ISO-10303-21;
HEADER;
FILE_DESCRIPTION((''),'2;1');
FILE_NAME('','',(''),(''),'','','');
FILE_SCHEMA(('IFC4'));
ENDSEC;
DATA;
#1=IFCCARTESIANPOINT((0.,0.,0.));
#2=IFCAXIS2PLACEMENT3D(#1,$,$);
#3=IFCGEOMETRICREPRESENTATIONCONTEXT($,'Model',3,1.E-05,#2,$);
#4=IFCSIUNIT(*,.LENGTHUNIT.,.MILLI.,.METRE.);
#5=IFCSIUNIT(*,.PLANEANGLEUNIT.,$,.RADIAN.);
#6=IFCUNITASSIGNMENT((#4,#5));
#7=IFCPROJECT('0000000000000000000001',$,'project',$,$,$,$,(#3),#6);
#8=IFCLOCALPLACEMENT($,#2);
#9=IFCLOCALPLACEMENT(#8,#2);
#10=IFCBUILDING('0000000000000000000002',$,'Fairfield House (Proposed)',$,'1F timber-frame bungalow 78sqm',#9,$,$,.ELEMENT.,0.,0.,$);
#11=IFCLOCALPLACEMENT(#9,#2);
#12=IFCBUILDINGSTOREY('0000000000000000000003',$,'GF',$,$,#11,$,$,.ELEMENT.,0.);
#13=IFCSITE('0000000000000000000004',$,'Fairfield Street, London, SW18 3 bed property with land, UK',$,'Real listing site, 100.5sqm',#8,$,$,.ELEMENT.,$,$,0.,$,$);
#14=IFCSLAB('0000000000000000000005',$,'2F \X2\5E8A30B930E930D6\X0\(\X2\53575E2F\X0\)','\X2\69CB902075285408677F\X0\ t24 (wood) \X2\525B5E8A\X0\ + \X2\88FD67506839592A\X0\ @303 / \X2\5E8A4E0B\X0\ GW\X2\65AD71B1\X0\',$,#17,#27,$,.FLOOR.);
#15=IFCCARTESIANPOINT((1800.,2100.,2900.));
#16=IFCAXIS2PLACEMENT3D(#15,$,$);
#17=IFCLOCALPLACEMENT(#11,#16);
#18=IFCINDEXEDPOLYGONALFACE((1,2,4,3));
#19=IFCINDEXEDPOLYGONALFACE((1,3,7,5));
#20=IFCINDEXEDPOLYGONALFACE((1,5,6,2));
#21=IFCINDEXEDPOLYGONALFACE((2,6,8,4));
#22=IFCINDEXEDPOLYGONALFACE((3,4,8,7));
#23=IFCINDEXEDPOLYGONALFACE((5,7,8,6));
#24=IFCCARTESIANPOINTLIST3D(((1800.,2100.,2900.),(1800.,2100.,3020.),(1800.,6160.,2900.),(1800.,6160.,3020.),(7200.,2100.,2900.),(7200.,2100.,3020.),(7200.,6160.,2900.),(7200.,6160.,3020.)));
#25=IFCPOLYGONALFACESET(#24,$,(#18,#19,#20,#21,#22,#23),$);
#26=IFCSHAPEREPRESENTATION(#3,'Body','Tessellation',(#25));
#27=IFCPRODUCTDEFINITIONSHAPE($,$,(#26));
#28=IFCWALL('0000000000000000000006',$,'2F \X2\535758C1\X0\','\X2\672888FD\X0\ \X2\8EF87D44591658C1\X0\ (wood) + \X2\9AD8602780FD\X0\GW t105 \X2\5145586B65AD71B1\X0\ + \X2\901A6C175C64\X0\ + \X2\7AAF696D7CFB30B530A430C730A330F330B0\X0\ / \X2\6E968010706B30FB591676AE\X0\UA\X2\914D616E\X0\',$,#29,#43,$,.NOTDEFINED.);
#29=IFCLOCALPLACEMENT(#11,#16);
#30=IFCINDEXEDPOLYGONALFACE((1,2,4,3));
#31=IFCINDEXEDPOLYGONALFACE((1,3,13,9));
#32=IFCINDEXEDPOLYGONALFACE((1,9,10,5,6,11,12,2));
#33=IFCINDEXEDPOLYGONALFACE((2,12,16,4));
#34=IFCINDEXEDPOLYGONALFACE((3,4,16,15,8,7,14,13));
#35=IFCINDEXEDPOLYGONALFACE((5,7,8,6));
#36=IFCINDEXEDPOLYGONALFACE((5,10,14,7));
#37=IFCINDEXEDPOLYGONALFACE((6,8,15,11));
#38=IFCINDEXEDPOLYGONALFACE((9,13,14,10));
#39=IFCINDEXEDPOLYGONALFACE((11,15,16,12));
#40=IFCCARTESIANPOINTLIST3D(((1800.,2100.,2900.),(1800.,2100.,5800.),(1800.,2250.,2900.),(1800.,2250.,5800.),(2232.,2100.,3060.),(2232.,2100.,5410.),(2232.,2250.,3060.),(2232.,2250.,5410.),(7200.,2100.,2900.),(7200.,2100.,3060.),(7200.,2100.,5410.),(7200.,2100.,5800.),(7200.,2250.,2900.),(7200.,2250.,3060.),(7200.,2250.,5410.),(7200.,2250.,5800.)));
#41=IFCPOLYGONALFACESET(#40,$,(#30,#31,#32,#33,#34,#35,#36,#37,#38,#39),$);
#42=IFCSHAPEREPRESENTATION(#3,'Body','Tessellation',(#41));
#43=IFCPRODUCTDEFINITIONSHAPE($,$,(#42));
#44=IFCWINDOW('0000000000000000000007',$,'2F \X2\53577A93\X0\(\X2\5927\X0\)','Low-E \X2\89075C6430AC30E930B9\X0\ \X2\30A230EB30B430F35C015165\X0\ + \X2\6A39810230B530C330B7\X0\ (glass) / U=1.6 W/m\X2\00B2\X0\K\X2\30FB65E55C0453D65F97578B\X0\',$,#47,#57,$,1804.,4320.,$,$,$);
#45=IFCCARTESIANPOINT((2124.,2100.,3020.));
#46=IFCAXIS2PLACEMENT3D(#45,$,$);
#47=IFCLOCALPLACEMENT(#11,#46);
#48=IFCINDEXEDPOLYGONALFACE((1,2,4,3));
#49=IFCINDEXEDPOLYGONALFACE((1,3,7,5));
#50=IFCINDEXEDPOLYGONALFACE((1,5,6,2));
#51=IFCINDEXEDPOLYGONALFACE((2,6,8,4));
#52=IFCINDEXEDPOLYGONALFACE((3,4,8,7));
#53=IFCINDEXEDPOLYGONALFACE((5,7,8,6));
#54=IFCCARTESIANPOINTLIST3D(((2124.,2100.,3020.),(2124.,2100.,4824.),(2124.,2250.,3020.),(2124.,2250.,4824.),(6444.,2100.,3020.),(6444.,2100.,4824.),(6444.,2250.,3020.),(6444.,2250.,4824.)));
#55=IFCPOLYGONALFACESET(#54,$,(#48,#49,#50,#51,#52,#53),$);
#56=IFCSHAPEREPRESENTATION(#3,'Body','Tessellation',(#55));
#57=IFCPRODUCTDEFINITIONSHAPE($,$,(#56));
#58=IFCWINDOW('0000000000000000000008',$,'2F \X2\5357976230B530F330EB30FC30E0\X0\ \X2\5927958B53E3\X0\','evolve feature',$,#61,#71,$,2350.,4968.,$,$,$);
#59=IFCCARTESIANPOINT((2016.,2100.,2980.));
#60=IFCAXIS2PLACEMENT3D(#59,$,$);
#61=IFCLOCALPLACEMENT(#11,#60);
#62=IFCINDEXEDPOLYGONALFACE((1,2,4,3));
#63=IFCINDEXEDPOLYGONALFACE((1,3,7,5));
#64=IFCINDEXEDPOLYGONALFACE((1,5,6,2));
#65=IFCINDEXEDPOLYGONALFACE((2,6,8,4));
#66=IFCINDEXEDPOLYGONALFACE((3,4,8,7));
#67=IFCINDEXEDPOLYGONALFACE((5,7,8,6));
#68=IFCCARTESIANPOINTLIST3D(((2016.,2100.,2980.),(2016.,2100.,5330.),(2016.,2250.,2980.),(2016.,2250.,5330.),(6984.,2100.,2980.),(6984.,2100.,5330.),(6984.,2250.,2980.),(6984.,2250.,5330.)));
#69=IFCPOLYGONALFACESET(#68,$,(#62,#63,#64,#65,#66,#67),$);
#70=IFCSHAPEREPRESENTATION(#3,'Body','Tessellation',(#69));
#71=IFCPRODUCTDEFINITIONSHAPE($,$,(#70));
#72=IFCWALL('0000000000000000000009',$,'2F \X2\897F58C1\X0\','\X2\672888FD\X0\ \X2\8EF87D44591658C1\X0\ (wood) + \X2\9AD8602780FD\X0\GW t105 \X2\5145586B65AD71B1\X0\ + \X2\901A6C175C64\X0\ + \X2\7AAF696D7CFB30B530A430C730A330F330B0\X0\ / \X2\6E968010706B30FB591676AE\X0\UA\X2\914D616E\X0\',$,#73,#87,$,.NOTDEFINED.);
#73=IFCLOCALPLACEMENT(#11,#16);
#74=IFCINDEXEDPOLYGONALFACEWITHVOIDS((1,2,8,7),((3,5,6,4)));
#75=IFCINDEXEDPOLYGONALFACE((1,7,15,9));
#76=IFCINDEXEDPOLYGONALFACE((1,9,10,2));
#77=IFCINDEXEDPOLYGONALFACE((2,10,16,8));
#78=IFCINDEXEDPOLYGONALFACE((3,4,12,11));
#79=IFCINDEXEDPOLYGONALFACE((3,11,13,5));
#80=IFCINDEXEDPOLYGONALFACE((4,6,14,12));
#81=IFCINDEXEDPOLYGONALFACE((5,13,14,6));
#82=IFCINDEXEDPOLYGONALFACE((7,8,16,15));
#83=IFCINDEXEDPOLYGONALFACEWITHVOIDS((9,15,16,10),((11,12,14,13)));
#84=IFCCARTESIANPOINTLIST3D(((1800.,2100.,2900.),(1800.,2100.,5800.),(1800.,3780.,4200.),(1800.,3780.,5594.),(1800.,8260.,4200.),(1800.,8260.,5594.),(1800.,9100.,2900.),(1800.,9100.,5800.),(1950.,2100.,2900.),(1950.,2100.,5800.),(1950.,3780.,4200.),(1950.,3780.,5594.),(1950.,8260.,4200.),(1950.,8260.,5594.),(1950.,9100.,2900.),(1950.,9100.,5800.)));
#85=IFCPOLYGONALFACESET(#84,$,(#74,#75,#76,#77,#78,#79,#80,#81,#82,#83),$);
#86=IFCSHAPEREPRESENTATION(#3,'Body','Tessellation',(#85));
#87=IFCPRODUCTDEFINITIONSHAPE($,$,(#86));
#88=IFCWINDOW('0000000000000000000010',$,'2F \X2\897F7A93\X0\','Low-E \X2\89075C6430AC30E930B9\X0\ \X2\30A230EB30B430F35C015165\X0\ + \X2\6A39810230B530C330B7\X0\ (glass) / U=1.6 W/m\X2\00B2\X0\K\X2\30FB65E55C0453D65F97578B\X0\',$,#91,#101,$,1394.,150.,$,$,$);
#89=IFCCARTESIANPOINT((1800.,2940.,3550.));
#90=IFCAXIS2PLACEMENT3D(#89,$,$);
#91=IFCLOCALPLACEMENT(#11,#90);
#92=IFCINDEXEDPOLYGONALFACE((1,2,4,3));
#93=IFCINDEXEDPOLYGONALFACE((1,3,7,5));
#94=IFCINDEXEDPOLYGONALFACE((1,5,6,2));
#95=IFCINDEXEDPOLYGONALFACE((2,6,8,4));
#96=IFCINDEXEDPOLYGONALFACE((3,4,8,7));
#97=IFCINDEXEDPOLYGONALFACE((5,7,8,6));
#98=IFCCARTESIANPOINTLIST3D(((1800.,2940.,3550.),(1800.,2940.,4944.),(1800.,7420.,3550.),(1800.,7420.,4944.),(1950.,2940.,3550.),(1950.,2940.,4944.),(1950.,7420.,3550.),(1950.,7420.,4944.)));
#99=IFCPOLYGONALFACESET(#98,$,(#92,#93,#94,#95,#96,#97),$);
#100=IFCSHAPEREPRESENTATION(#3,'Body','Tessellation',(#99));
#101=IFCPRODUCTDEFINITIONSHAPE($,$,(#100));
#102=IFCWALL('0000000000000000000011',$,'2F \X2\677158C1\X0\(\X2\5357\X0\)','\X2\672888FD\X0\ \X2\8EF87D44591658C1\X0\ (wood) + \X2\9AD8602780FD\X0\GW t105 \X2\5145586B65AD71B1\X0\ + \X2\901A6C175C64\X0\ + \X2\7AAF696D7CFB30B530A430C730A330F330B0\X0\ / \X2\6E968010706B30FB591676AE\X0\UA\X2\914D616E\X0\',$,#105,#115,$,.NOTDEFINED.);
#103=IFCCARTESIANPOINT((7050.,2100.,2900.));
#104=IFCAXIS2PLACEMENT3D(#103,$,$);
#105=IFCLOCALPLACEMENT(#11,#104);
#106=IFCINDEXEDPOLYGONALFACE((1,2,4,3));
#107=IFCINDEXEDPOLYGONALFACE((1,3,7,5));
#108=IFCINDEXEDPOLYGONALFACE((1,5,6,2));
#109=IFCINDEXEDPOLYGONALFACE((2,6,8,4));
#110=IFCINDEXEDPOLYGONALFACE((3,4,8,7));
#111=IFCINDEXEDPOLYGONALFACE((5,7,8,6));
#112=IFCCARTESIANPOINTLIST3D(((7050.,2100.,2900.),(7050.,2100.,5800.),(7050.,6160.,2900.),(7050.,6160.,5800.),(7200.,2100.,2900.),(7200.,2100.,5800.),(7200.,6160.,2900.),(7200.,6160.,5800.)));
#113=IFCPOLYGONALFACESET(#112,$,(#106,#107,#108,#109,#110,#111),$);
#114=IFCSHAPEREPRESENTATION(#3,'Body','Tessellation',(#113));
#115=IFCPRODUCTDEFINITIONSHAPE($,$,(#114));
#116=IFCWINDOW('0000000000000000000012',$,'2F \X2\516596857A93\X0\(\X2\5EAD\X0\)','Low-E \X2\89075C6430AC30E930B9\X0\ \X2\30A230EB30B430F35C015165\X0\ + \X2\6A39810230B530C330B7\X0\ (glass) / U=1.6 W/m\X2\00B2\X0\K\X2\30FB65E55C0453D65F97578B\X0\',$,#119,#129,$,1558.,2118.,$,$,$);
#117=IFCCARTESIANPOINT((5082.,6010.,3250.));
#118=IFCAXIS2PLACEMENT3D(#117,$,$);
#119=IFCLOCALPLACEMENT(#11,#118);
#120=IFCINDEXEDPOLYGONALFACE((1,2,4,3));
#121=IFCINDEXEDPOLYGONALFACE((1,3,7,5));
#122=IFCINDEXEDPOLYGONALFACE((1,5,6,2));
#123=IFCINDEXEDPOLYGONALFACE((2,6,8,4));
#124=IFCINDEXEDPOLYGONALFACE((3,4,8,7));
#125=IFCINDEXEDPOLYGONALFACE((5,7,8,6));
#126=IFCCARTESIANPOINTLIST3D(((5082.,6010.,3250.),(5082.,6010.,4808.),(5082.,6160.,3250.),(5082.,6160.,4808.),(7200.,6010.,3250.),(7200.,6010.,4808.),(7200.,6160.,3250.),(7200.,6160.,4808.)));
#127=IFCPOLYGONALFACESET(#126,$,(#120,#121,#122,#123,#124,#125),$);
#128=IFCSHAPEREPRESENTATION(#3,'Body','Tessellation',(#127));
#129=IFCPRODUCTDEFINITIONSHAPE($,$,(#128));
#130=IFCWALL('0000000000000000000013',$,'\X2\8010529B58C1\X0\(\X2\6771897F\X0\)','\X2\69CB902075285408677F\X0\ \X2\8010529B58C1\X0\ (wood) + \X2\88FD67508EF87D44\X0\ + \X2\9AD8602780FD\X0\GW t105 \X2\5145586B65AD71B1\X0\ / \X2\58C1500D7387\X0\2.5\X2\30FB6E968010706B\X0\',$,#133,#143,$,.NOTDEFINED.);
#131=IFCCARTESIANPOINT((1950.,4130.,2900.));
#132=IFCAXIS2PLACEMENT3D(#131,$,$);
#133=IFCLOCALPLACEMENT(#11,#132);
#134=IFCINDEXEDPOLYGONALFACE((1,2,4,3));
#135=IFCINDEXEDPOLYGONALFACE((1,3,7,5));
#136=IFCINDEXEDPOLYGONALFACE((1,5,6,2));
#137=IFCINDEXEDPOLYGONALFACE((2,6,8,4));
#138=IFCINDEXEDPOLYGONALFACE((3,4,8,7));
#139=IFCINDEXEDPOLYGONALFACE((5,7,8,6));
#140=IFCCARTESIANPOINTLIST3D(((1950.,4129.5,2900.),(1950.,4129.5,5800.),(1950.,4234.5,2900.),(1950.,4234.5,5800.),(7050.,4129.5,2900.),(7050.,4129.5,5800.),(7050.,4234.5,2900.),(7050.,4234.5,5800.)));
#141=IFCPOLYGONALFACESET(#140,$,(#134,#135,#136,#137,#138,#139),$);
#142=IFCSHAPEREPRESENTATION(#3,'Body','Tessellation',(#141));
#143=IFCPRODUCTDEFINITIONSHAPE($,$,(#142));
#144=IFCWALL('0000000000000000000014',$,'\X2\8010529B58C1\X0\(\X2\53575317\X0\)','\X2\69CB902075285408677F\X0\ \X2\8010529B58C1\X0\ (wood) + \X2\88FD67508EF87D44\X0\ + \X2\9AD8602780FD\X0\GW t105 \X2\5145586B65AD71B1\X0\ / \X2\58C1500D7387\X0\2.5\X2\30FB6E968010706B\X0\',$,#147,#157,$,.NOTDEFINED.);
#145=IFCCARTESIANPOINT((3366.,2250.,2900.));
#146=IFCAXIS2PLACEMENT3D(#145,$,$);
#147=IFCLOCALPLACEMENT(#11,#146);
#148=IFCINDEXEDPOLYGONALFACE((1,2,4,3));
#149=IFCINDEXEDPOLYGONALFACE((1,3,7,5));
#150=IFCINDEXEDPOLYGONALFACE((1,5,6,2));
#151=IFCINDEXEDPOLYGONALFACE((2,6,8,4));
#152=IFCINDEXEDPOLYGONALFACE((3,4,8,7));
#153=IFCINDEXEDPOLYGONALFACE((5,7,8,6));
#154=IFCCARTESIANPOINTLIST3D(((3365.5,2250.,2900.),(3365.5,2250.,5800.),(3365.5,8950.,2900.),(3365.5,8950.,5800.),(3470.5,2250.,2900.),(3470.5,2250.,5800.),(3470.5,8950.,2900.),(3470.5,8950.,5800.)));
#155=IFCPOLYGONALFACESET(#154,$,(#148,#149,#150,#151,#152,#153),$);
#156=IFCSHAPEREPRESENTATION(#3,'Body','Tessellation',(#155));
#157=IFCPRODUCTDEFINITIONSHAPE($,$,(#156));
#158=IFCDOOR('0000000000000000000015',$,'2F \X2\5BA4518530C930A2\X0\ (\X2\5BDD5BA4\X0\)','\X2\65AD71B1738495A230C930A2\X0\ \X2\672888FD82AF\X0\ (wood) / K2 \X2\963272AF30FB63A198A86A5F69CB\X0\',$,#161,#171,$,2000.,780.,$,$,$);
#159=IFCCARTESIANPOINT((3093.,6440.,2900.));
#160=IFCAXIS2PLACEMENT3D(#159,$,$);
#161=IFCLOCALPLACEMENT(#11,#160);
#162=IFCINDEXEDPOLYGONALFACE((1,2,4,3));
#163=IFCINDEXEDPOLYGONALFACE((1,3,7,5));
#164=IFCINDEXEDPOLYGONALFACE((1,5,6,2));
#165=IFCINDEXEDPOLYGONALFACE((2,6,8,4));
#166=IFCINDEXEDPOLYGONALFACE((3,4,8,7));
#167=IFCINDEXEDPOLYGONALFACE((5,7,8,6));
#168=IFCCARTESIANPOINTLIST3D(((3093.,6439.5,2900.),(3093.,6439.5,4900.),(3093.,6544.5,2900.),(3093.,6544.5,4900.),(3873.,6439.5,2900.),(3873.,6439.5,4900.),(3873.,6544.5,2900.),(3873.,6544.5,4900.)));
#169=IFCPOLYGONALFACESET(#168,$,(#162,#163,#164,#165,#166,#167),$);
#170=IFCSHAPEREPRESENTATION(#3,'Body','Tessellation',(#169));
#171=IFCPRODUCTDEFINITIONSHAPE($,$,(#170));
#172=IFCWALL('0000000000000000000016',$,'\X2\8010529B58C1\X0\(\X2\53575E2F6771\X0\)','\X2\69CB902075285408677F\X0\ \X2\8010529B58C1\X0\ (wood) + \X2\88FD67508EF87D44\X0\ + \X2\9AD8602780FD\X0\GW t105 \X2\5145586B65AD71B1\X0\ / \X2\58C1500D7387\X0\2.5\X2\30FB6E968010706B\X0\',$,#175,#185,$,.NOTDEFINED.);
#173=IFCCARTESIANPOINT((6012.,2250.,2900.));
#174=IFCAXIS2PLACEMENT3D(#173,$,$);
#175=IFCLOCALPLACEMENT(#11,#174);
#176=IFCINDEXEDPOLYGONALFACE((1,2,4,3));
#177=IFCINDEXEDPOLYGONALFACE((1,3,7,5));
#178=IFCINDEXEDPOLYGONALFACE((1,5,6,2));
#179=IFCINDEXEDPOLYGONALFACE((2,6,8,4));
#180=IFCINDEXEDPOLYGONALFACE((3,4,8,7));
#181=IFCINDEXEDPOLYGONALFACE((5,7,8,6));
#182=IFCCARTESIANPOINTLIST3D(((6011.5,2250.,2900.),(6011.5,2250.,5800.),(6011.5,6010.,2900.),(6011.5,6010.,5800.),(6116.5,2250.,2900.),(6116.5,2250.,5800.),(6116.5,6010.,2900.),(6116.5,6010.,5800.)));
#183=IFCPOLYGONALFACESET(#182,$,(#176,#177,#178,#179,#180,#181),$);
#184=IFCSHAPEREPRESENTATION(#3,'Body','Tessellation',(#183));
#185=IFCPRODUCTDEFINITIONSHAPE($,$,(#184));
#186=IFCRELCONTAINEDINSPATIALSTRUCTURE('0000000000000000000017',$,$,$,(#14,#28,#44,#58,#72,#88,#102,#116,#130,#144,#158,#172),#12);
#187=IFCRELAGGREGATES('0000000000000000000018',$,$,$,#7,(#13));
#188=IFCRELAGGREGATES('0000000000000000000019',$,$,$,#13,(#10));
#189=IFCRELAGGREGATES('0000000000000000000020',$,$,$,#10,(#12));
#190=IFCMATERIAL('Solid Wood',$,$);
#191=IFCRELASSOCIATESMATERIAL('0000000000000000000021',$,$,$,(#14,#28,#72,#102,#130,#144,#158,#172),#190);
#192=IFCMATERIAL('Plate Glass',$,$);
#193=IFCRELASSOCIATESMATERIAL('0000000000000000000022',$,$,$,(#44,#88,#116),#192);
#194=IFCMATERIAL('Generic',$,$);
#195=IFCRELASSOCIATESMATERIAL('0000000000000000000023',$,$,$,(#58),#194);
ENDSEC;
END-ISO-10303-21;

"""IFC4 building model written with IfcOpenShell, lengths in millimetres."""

from ifc_helpers import new_model, si_unit, frame, frame_2d, origin, place, context, project, spatial, rectangle, extrude, material, element, fill, save


model = new_model("IFC4")

# Units and contexts
model_context = context("Model", 3, precision=1e-05, world=origin())
ifc_project = project(units=[si_unit("LENGTHUNIT", "METRE", prefix="MILLI"), si_unit("PLANEANGLEUNIT", "RADIAN")], contexts=[model_context])

# Site, building, storey
site_placement = place(None, origin())
site = spatial("IfcSite", under=ifc_project, at=site_placement, Name="Fairfield Street, London, SW18 3 bed property with land, UK", ObjectType="Real listing site, 100.5sqm", CompositionType="ELEMENT", RefElevation=0.0)
building_placement = place(site_placement, origin())
building = spatial("IfcBuilding", under=site, at=building_placement, Name="Fairfield House (Proposed)", ObjectType="1F timber-frame bungalow 78sqm", CompositionType="ELEMENT", ElevationOfRefHeight=0.0, ElevationOfTerrain=0.0)
storey_placement = place(building_placement, origin())
storey = spatial("IfcBuildingStorey", under=building, at=storey_placement, Name="GF", CompositionType="ELEMENT", Elevation=0.0)

# Slab
ifc_material_1 = material(Name="Solid Wood")
slab_placement = place(storey_placement, frame((1800.0, 2100.0, 2900.0)))
element("IfcSlab", 1, at=slab_placement, inside=storey, material=ifc_material_1, Name="2F 床スラブ(南帯)", Description="構造用合板 t24 (wood) 剛床 + 製材根太 @303 / 床下 GW断熱", PredefinedType="FLOOR", context=model_context, shape_type="SweptSolid", body=[
    extrude(rectangle(XDim=5400.0, YDim=4060.0, at=frame_2d((2700.0, 2030.0))), frame((1800.0, 2100.0, 2900.0)), (0.0, 0.0, 1.0), 120.0),
])

# Wall, openings, windows
wall_1_placement = place(storey_placement, frame((1800.0, 2100.0, 2900.0)))
wall_1 = element("IfcWall", 2, at=wall_1_placement, inside=storey, material=ifc_material_1, Name="2F 南壁", Description="木製 軸組外壁 (wood) + 高性能GW t105 充填断熱 + 通気層 + 窯業系サイディング / 準耐火・外皮UA配慮", PredefinedType="NOTDEFINED", context=model_context, shape_type="SweptSolid", body=[
    extrude(rectangle(XDim=5400.0, YDim=150.0, at=frame_2d((2700.0, 75.0))), frame((1800.0, 2100.0, 2900.0)), (0.0, 0.0, 1.0), 2900.0),
])
opening_1_placement = place(storey_placement, frame((2124.0, 2100.0, 3020.0)))
opening_1 = element("IfcOpeningElement", 3, at=opening_1_placement, cuts=wall_1, PredefinedType="NOTDEFINED", context=model_context, shape_type="SweptSolid", body=[
    extrude(rectangle(XDim=4320.0, YDim=150.0, at=frame_2d((2160.0, 75.0))), frame((2124.0, 2100.0, 3020.0)), (0.0, 0.0, 1.0), 1804.0),
])
opening_2_placement = place(storey_placement, frame((2016.0, 2100.0, 2980.0)))
opening_2 = element("IfcOpeningElement", 4, at=opening_2_placement, cuts=wall_1, PredefinedType="NOTDEFINED", context=model_context, shape_type="SweptSolid", body=[
    extrude(rectangle(XDim=4968.0, YDim=150.0, at=frame_2d((2484.0, 75.0))), frame((2016.0, 2100.0, 2980.0)), (0.0, 0.0, 1.0), 2350.0),
])
ifc_material_2 = material(Name="Plate Glass")
window_1_placement = place(storey_placement, frame((2124.0, 2100.0, 3020.0)))
window_1 = element("IfcWindow", 5, at=window_1_placement, inside=storey, material=ifc_material_2, Name="2F 南窓(大)", Description="Low-E 複層ガラス アルゴン封入 + 樹脂サッシ (glass) / U=1.6 W/m²K・日射取得型", OverallHeight=1804.0, OverallWidth=4320.0, context=model_context, shape_type="SweptSolid", body=[
    extrude(rectangle(XDim=4320.0, YDim=150.0, at=frame_2d((2160.0, 75.0))), frame((2124.0, 2100.0, 3020.0)), (0.0, 0.0, 1.0), 1804.0),
])
fill(opening_1, window_1)
ifc_material_3 = material(Name="Generic")
window_2_placement = place(storey_placement, frame((2016.0, 2100.0, 2980.0)))
window_2 = element("IfcWindow", 6, at=window_2_placement, inside=storey, material=ifc_material_3, Name="2F 南面サンルーム 大開口", Description="evolve feature", OverallHeight=2350.0, OverallWidth=4968.0, context=model_context, shape_type="SweptSolid", body=[
    extrude(rectangle(XDim=4968.0, YDim=150.0, at=frame_2d((2484.0, 75.0))), frame((2016.0, 2100.0, 2980.0)), (0.0, 0.0, 1.0), 2350.0),
])
fill(opening_2, window_2)

# Walls, openings, windows
wall_2_placement = place(storey_placement, frame((1800.0, 2100.0, 2900.0)))
wall_2 = element("IfcWall", 7, at=wall_2_placement, inside=storey, material=ifc_material_1, Name="2F 西壁", Description="木製 軸組外壁 (wood) + 高性能GW t105 充填断熱 + 通気層 + 窯業系サイディング / 準耐火・外皮UA配慮", PredefinedType="NOTDEFINED", context=model_context, shape_type="SweptSolid", body=[
    extrude(rectangle(XDim=150.0, YDim=7000.0, at=frame_2d((75.0, 3500.0))), frame((1800.0, 2100.0, 2900.0)), (0.0, 0.0, 1.0), 2900.0),
])
opening_3_placement = place(storey_placement, frame((1800.0, 2940.0, 3550.0)))
opening_3 = element("IfcOpeningElement", 8, at=opening_3_placement, cuts=wall_2, PredefinedType="NOTDEFINED", context=model_context, shape_type="SweptSolid", body=[
    extrude(rectangle(XDim=150.0, YDim=4480.0, at=frame_2d((75.0, 2240.0))), frame((1800.0, 2940.0, 3550.0)), (0.0, 0.0, 1.0), 1394.0),
])
window_3_placement = place(storey_placement, frame((1800.0, 2940.0, 3550.0)))
window_3 = element("IfcWindow", 9, at=window_3_placement, inside=storey, material=ifc_material_2, Name="2F 西窓", Description="Low-E 複層ガラス アルゴン封入 + 樹脂サッシ (glass) / U=1.6 W/m²K・日射取得型", OverallHeight=1394.0, OverallWidth=150.0, context=model_context, shape_type="SweptSolid", body=[
    extrude(rectangle(XDim=150.0, YDim=4480.0, at=frame_2d((75.0, 2240.0))), frame((1800.0, 2940.0, 3550.0)), (0.0, 0.0, 1.0), 1394.0),
])
fill(opening_3, window_3)
wall_3_placement = place(storey_placement, frame((7050.0, 2100.0, 2900.0)))
wall_3 = element("IfcWall", 10, at=wall_3_placement, inside=storey, material=ifc_material_1, Name="2F 東壁(南)", Description="木製 軸組外壁 (wood) + 高性能GW t105 充填断熱 + 通気層 + 窯業系サイディング / 準耐火・外皮UA配慮", PredefinedType="NOTDEFINED", context=model_context, shape_type="SweptSolid", body=[
    extrude(rectangle(XDim=150.0, YDim=4060.0, at=frame_2d((75.0, 2030.0))), frame((7050.0, 2100.0, 2900.0)), (0.0, 0.0, 1.0), 2900.0),
])
opening_4_placement = place(storey_placement, frame((5082.0, 6010.0, 3250.0)))
opening_4 = element("IfcOpeningElement", 11, at=opening_4_placement, cuts=wall_3, PredefinedType="NOTDEFINED", context=model_context, shape_type="SweptSolid", body=[
    extrude(rectangle(XDim=2118.0, YDim=150.0, at=frame_2d((1059.0, 75.0))), frame((5082.0, 6010.0, 3250.0)), (0.0, 0.0, 1.0), 1558.0),
])
window_4_placement = place(storey_placement, frame((5082.0, 6010.0, 3250.0)))
window_4 = element("IfcWindow", 12, at=window_4_placement, inside=storey, material=ifc_material_2, Name="2F 入隅窓(庭)", Description="Low-E 複層ガラス アルゴン封入 + 樹脂サッシ (glass) / U=1.6 W/m²K・日射取得型", OverallHeight=1558.0, OverallWidth=2118.0, context=model_context, shape_type="SweptSolid", body=[
    extrude(rectangle(XDim=2118.0, YDim=150.0, at=frame_2d((1059.0, 75.0))), frame((5082.0, 6010.0, 3250.0)), (0.0, 0.0, 1.0), 1558.0),
])
fill(opening_4, window_4)

# Wall
wall_4_placement = place(storey_placement, frame((1950.0, 4130.0, 2900.0)))
element("IfcWall", 13, at=wall_4_placement, inside=storey, material=ifc_material_1, Name="耐力壁(東西)", Description="構造用合板 耐力壁 (wood) + 製材軸組 + 高性能GW t105 充填断熱 / 壁倍率2.5・準耐火", PredefinedType="NOTDEFINED", context=model_context, shape_type="SweptSolid", body=[
    extrude(rectangle(XDim=5100.0, YDim=105.0, at=frame_2d((2550.0, 52.0))), frame((1950.0, 4130.0, 2900.0)), (0.0, 0.0, 1.0), 2900.0),
])

# Wall, opening, door
wall_5_placement = place(storey_placement, frame((3366.0, 2250.0, 2900.0)))
wall_5 = element("IfcWall", 14, at=wall_5_placement, inside=storey, material=ifc_material_1, Name="耐力壁(南北)", Description="構造用合板 耐力壁 (wood) + 製材軸組 + 高性能GW t105 充填断熱 / 壁倍率2.5・準耐火", PredefinedType="NOTDEFINED", context=model_context, shape_type="SweptSolid", body=[
    extrude(rectangle(XDim=105.0, YDim=6700.0, at=frame_2d((52.0, 3350.0))), frame((3366.0, 2250.0, 2900.0)), (0.0, 0.0, 1.0), 2900.0),
])
opening_5_placement = place(storey_placement, frame((3093.0, 6440.0, 2900.0)))
opening_5 = element("IfcOpeningElement", 15, at=opening_5_placement, cuts=wall_5, PredefinedType="NOTDEFINED", context=model_context, shape_type="SweptSolid", body=[
    extrude(rectangle(XDim=780.0, YDim=105.0, at=frame_2d((390.0, 52.0))), frame((3093.0, 6440.0, 2900.0)), (0.0, 0.0, 1.0), 2000.0),
])
door_placement = place(storey_placement, frame((3093.0, 6440.0, 2900.0)))
door = element("IfcDoor", 16, at=door_placement, inside=storey, material=ifc_material_1, Name="2F 室内ドア (寝室)", Description="断熱玄関ドア 木製芯 (wood) / K2 防犯・採風機構", OverallHeight=2000.0, OverallWidth=780.0, context=model_context, shape_type="SweptSolid", body=[
    extrude(rectangle(XDim=780.0, YDim=105.0, at=frame_2d((390.0, 52.0))), frame((3093.0, 6440.0, 2900.0)), (0.0, 0.0, 1.0), 2000.0),
])
fill(opening_5, door)

# Wall
wall_6_placement = place(storey_placement, frame((6012.0, 2250.0, 2900.0)))
element("IfcWall", 17, at=wall_6_placement, inside=storey, material=ifc_material_1, Name="耐力壁(南帯東)", Description="構造用合板 耐力壁 (wood) + 製材軸組 + 高性能GW t105 充填断熱 / 壁倍率2.5・準耐火", PredefinedType="NOTDEFINED", context=model_context, shape_type="SweptSolid", body=[
    extrude(rectangle(XDim=105.0, YDim=3760.0, at=frame_2d((52.0, 1880.0))), frame((6012.0, 2250.0, 2900.0)), (0.0, 0.0, 1.0), 2900.0),
])

save(model, "model.ifc")
